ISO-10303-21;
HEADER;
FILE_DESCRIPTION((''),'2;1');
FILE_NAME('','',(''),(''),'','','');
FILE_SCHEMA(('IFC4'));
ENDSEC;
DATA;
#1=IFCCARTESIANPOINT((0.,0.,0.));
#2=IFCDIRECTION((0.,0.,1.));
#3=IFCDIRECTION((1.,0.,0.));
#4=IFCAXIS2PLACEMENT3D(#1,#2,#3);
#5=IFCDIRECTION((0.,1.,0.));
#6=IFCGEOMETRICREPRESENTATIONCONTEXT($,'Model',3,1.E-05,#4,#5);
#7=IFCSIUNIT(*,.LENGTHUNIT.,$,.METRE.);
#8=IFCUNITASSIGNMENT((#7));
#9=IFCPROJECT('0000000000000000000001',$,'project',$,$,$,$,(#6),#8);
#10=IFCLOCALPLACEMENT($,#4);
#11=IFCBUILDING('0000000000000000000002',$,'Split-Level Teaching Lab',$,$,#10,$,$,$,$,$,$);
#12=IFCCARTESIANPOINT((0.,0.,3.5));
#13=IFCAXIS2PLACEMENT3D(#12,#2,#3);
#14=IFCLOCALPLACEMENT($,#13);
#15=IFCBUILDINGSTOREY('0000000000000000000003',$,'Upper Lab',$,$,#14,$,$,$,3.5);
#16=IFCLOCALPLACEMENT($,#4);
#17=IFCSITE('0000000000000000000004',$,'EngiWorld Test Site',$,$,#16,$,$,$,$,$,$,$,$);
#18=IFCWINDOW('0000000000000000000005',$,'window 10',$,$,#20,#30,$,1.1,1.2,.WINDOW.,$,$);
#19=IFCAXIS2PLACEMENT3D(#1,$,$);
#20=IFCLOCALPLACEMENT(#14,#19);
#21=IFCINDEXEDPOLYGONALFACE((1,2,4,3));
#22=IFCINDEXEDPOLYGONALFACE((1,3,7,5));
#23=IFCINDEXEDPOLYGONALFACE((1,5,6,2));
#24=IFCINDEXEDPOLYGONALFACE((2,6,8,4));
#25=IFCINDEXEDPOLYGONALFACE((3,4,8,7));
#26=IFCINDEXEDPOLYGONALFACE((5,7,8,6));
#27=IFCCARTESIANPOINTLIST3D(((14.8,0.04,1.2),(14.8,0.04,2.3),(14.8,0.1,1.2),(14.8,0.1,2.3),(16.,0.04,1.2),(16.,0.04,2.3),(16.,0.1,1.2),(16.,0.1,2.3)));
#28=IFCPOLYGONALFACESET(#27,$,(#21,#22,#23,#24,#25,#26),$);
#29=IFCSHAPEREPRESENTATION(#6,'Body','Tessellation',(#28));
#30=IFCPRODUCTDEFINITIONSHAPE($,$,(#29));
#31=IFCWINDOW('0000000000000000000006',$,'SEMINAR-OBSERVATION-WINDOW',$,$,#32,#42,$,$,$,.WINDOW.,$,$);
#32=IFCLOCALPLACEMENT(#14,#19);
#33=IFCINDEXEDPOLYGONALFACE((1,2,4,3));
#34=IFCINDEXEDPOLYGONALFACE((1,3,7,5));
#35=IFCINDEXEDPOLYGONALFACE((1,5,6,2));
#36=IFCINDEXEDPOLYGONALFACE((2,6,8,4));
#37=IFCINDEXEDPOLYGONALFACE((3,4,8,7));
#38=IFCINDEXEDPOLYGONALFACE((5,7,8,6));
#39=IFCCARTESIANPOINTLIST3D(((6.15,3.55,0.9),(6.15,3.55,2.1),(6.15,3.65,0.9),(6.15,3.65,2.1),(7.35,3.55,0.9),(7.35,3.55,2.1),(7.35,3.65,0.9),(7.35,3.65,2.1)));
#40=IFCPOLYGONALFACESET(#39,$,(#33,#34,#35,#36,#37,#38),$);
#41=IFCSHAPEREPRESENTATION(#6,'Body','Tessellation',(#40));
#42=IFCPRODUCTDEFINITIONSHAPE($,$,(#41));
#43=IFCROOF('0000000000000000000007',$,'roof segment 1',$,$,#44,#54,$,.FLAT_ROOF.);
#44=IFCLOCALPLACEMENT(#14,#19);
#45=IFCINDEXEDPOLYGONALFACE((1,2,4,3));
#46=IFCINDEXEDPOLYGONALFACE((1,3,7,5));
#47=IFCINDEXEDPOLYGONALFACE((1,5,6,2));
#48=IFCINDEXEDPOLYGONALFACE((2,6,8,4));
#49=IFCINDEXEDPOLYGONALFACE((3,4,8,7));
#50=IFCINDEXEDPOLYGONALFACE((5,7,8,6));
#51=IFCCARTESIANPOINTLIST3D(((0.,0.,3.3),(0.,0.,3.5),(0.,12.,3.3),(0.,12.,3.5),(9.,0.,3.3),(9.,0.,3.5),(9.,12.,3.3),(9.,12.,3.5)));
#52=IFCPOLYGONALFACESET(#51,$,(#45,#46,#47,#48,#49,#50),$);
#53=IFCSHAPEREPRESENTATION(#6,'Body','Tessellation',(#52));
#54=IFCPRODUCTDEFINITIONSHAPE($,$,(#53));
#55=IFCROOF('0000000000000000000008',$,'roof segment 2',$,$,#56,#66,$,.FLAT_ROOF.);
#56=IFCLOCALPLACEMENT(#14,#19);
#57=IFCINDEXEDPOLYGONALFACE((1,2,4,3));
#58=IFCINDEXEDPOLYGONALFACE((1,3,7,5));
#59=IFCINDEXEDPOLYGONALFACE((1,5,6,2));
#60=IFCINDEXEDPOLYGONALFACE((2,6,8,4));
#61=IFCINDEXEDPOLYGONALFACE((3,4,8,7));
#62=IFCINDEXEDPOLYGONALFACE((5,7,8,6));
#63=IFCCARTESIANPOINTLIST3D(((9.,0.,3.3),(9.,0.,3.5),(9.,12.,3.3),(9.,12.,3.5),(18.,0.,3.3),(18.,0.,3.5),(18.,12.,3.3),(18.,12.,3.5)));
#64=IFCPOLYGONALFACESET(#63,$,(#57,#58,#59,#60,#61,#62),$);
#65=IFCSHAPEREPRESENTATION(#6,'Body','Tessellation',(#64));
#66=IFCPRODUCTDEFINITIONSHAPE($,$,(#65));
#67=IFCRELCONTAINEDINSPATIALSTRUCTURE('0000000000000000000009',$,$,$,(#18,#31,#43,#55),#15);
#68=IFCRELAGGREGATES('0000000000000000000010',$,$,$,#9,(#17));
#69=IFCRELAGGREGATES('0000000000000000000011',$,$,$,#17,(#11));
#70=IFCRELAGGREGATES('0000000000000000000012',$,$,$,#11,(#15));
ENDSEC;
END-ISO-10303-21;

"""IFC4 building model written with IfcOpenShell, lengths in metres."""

from ifc_helpers import new_model, si_unit, direction, frame, origin, origin_with_axes, origin_2d, origin_2d_with_axis, place, context, project, spatial, rectangle, extrude, element, save


model = new_model("IFC4")

# Units and contexts
model_context = context("Model", 3, precision=1e-05, world=origin_with_axes(), true_north=direction((0.0, 1.0, 0.0)))
ifc_project = project(units=[si_unit("LENGTHUNIT", "METRE")], contexts=[model_context])

# Site, building, storey
site_placement = place(None, origin_with_axes())
site = spatial("IfcSite", under=ifc_project, at=site_placement, Name="EngiWorld Test Site")
building_placement = place(None, origin_with_axes())
building = spatial("IfcBuilding", under=site, at=building_placement, Name="Split-Level Teaching Lab")
storey_placement = place(None, frame((0.0, 0.0, 3.5), z_axis=(0.0, 0.0, 1.0), x_axis=(1.0, 0.0, 0.0)))
storey = spatial("IfcBuildingStorey", under=building, at=storey_placement, Name="Upper Lab", Elevation=3.5)

# Windows
for number, where, z_axis, x_axis, name in (
    (1, (15.4, 0.07, 4.7), (0.0, 0.0, 1.0), (1.0, 0.0, 0.0), "window 10"),
):
    element("IfcWindow", number, at=place(None, frame(where, z_axis=z_axis, x_axis=x_axis)), inside=storey, Name=name, OverallHeight=1.1, OverallWidth=1.2, PredefinedType="WINDOW", context=model_context, shape_type="SweptSolid", body=[
        extrude(rectangle(XDim=1.2, YDim=0.06, at=origin_2d_with_axis()), origin_with_axes(), (0.0, 0.0, 1.0), 1.1),
    ])
window_placement = place(None, frame((6.75, 3.6, 4.4)))
element("IfcWindow", 2, at=window_placement, inside=storey, Name="SEMINAR-OBSERVATION-WINDOW", PredefinedType="WINDOW", context=model_context, shape_type="SweptSolid", body=[
    extrude(rectangle(XDim=1.2, YDim=0.1, at=origin_2d()), origin(), (0.0, 0.0, 1.0), 1.2),
])

# Roofs
for number, where, z_axis, x_axis, name in (
    (3, (4.5, 6.0, 6.8), (0.0, 0.0, 1.0), (1.0, 0.0, 0.0), "roof segment 1"),
    (4, (13.5, 6.0, 6.8), (0.0, 0.0, 1.0), (1.0, 0.0, 0.0), "roof segment 2"),
):
    element("IfcRoof", number, at=place(None, frame(where, z_axis=z_axis, x_axis=x_axis)), inside=storey, Name=name, PredefinedType="FLAT_ROOF", context=model_context, shape_type="SweptSolid", body=[
        extrude(rectangle(XDim=9.0, YDim=12.0, at=origin_2d_with_axis()), origin_with_axes(), (0.0, 0.0, 1.0), 0.2),
    ])

save(model, "model.ifc")
